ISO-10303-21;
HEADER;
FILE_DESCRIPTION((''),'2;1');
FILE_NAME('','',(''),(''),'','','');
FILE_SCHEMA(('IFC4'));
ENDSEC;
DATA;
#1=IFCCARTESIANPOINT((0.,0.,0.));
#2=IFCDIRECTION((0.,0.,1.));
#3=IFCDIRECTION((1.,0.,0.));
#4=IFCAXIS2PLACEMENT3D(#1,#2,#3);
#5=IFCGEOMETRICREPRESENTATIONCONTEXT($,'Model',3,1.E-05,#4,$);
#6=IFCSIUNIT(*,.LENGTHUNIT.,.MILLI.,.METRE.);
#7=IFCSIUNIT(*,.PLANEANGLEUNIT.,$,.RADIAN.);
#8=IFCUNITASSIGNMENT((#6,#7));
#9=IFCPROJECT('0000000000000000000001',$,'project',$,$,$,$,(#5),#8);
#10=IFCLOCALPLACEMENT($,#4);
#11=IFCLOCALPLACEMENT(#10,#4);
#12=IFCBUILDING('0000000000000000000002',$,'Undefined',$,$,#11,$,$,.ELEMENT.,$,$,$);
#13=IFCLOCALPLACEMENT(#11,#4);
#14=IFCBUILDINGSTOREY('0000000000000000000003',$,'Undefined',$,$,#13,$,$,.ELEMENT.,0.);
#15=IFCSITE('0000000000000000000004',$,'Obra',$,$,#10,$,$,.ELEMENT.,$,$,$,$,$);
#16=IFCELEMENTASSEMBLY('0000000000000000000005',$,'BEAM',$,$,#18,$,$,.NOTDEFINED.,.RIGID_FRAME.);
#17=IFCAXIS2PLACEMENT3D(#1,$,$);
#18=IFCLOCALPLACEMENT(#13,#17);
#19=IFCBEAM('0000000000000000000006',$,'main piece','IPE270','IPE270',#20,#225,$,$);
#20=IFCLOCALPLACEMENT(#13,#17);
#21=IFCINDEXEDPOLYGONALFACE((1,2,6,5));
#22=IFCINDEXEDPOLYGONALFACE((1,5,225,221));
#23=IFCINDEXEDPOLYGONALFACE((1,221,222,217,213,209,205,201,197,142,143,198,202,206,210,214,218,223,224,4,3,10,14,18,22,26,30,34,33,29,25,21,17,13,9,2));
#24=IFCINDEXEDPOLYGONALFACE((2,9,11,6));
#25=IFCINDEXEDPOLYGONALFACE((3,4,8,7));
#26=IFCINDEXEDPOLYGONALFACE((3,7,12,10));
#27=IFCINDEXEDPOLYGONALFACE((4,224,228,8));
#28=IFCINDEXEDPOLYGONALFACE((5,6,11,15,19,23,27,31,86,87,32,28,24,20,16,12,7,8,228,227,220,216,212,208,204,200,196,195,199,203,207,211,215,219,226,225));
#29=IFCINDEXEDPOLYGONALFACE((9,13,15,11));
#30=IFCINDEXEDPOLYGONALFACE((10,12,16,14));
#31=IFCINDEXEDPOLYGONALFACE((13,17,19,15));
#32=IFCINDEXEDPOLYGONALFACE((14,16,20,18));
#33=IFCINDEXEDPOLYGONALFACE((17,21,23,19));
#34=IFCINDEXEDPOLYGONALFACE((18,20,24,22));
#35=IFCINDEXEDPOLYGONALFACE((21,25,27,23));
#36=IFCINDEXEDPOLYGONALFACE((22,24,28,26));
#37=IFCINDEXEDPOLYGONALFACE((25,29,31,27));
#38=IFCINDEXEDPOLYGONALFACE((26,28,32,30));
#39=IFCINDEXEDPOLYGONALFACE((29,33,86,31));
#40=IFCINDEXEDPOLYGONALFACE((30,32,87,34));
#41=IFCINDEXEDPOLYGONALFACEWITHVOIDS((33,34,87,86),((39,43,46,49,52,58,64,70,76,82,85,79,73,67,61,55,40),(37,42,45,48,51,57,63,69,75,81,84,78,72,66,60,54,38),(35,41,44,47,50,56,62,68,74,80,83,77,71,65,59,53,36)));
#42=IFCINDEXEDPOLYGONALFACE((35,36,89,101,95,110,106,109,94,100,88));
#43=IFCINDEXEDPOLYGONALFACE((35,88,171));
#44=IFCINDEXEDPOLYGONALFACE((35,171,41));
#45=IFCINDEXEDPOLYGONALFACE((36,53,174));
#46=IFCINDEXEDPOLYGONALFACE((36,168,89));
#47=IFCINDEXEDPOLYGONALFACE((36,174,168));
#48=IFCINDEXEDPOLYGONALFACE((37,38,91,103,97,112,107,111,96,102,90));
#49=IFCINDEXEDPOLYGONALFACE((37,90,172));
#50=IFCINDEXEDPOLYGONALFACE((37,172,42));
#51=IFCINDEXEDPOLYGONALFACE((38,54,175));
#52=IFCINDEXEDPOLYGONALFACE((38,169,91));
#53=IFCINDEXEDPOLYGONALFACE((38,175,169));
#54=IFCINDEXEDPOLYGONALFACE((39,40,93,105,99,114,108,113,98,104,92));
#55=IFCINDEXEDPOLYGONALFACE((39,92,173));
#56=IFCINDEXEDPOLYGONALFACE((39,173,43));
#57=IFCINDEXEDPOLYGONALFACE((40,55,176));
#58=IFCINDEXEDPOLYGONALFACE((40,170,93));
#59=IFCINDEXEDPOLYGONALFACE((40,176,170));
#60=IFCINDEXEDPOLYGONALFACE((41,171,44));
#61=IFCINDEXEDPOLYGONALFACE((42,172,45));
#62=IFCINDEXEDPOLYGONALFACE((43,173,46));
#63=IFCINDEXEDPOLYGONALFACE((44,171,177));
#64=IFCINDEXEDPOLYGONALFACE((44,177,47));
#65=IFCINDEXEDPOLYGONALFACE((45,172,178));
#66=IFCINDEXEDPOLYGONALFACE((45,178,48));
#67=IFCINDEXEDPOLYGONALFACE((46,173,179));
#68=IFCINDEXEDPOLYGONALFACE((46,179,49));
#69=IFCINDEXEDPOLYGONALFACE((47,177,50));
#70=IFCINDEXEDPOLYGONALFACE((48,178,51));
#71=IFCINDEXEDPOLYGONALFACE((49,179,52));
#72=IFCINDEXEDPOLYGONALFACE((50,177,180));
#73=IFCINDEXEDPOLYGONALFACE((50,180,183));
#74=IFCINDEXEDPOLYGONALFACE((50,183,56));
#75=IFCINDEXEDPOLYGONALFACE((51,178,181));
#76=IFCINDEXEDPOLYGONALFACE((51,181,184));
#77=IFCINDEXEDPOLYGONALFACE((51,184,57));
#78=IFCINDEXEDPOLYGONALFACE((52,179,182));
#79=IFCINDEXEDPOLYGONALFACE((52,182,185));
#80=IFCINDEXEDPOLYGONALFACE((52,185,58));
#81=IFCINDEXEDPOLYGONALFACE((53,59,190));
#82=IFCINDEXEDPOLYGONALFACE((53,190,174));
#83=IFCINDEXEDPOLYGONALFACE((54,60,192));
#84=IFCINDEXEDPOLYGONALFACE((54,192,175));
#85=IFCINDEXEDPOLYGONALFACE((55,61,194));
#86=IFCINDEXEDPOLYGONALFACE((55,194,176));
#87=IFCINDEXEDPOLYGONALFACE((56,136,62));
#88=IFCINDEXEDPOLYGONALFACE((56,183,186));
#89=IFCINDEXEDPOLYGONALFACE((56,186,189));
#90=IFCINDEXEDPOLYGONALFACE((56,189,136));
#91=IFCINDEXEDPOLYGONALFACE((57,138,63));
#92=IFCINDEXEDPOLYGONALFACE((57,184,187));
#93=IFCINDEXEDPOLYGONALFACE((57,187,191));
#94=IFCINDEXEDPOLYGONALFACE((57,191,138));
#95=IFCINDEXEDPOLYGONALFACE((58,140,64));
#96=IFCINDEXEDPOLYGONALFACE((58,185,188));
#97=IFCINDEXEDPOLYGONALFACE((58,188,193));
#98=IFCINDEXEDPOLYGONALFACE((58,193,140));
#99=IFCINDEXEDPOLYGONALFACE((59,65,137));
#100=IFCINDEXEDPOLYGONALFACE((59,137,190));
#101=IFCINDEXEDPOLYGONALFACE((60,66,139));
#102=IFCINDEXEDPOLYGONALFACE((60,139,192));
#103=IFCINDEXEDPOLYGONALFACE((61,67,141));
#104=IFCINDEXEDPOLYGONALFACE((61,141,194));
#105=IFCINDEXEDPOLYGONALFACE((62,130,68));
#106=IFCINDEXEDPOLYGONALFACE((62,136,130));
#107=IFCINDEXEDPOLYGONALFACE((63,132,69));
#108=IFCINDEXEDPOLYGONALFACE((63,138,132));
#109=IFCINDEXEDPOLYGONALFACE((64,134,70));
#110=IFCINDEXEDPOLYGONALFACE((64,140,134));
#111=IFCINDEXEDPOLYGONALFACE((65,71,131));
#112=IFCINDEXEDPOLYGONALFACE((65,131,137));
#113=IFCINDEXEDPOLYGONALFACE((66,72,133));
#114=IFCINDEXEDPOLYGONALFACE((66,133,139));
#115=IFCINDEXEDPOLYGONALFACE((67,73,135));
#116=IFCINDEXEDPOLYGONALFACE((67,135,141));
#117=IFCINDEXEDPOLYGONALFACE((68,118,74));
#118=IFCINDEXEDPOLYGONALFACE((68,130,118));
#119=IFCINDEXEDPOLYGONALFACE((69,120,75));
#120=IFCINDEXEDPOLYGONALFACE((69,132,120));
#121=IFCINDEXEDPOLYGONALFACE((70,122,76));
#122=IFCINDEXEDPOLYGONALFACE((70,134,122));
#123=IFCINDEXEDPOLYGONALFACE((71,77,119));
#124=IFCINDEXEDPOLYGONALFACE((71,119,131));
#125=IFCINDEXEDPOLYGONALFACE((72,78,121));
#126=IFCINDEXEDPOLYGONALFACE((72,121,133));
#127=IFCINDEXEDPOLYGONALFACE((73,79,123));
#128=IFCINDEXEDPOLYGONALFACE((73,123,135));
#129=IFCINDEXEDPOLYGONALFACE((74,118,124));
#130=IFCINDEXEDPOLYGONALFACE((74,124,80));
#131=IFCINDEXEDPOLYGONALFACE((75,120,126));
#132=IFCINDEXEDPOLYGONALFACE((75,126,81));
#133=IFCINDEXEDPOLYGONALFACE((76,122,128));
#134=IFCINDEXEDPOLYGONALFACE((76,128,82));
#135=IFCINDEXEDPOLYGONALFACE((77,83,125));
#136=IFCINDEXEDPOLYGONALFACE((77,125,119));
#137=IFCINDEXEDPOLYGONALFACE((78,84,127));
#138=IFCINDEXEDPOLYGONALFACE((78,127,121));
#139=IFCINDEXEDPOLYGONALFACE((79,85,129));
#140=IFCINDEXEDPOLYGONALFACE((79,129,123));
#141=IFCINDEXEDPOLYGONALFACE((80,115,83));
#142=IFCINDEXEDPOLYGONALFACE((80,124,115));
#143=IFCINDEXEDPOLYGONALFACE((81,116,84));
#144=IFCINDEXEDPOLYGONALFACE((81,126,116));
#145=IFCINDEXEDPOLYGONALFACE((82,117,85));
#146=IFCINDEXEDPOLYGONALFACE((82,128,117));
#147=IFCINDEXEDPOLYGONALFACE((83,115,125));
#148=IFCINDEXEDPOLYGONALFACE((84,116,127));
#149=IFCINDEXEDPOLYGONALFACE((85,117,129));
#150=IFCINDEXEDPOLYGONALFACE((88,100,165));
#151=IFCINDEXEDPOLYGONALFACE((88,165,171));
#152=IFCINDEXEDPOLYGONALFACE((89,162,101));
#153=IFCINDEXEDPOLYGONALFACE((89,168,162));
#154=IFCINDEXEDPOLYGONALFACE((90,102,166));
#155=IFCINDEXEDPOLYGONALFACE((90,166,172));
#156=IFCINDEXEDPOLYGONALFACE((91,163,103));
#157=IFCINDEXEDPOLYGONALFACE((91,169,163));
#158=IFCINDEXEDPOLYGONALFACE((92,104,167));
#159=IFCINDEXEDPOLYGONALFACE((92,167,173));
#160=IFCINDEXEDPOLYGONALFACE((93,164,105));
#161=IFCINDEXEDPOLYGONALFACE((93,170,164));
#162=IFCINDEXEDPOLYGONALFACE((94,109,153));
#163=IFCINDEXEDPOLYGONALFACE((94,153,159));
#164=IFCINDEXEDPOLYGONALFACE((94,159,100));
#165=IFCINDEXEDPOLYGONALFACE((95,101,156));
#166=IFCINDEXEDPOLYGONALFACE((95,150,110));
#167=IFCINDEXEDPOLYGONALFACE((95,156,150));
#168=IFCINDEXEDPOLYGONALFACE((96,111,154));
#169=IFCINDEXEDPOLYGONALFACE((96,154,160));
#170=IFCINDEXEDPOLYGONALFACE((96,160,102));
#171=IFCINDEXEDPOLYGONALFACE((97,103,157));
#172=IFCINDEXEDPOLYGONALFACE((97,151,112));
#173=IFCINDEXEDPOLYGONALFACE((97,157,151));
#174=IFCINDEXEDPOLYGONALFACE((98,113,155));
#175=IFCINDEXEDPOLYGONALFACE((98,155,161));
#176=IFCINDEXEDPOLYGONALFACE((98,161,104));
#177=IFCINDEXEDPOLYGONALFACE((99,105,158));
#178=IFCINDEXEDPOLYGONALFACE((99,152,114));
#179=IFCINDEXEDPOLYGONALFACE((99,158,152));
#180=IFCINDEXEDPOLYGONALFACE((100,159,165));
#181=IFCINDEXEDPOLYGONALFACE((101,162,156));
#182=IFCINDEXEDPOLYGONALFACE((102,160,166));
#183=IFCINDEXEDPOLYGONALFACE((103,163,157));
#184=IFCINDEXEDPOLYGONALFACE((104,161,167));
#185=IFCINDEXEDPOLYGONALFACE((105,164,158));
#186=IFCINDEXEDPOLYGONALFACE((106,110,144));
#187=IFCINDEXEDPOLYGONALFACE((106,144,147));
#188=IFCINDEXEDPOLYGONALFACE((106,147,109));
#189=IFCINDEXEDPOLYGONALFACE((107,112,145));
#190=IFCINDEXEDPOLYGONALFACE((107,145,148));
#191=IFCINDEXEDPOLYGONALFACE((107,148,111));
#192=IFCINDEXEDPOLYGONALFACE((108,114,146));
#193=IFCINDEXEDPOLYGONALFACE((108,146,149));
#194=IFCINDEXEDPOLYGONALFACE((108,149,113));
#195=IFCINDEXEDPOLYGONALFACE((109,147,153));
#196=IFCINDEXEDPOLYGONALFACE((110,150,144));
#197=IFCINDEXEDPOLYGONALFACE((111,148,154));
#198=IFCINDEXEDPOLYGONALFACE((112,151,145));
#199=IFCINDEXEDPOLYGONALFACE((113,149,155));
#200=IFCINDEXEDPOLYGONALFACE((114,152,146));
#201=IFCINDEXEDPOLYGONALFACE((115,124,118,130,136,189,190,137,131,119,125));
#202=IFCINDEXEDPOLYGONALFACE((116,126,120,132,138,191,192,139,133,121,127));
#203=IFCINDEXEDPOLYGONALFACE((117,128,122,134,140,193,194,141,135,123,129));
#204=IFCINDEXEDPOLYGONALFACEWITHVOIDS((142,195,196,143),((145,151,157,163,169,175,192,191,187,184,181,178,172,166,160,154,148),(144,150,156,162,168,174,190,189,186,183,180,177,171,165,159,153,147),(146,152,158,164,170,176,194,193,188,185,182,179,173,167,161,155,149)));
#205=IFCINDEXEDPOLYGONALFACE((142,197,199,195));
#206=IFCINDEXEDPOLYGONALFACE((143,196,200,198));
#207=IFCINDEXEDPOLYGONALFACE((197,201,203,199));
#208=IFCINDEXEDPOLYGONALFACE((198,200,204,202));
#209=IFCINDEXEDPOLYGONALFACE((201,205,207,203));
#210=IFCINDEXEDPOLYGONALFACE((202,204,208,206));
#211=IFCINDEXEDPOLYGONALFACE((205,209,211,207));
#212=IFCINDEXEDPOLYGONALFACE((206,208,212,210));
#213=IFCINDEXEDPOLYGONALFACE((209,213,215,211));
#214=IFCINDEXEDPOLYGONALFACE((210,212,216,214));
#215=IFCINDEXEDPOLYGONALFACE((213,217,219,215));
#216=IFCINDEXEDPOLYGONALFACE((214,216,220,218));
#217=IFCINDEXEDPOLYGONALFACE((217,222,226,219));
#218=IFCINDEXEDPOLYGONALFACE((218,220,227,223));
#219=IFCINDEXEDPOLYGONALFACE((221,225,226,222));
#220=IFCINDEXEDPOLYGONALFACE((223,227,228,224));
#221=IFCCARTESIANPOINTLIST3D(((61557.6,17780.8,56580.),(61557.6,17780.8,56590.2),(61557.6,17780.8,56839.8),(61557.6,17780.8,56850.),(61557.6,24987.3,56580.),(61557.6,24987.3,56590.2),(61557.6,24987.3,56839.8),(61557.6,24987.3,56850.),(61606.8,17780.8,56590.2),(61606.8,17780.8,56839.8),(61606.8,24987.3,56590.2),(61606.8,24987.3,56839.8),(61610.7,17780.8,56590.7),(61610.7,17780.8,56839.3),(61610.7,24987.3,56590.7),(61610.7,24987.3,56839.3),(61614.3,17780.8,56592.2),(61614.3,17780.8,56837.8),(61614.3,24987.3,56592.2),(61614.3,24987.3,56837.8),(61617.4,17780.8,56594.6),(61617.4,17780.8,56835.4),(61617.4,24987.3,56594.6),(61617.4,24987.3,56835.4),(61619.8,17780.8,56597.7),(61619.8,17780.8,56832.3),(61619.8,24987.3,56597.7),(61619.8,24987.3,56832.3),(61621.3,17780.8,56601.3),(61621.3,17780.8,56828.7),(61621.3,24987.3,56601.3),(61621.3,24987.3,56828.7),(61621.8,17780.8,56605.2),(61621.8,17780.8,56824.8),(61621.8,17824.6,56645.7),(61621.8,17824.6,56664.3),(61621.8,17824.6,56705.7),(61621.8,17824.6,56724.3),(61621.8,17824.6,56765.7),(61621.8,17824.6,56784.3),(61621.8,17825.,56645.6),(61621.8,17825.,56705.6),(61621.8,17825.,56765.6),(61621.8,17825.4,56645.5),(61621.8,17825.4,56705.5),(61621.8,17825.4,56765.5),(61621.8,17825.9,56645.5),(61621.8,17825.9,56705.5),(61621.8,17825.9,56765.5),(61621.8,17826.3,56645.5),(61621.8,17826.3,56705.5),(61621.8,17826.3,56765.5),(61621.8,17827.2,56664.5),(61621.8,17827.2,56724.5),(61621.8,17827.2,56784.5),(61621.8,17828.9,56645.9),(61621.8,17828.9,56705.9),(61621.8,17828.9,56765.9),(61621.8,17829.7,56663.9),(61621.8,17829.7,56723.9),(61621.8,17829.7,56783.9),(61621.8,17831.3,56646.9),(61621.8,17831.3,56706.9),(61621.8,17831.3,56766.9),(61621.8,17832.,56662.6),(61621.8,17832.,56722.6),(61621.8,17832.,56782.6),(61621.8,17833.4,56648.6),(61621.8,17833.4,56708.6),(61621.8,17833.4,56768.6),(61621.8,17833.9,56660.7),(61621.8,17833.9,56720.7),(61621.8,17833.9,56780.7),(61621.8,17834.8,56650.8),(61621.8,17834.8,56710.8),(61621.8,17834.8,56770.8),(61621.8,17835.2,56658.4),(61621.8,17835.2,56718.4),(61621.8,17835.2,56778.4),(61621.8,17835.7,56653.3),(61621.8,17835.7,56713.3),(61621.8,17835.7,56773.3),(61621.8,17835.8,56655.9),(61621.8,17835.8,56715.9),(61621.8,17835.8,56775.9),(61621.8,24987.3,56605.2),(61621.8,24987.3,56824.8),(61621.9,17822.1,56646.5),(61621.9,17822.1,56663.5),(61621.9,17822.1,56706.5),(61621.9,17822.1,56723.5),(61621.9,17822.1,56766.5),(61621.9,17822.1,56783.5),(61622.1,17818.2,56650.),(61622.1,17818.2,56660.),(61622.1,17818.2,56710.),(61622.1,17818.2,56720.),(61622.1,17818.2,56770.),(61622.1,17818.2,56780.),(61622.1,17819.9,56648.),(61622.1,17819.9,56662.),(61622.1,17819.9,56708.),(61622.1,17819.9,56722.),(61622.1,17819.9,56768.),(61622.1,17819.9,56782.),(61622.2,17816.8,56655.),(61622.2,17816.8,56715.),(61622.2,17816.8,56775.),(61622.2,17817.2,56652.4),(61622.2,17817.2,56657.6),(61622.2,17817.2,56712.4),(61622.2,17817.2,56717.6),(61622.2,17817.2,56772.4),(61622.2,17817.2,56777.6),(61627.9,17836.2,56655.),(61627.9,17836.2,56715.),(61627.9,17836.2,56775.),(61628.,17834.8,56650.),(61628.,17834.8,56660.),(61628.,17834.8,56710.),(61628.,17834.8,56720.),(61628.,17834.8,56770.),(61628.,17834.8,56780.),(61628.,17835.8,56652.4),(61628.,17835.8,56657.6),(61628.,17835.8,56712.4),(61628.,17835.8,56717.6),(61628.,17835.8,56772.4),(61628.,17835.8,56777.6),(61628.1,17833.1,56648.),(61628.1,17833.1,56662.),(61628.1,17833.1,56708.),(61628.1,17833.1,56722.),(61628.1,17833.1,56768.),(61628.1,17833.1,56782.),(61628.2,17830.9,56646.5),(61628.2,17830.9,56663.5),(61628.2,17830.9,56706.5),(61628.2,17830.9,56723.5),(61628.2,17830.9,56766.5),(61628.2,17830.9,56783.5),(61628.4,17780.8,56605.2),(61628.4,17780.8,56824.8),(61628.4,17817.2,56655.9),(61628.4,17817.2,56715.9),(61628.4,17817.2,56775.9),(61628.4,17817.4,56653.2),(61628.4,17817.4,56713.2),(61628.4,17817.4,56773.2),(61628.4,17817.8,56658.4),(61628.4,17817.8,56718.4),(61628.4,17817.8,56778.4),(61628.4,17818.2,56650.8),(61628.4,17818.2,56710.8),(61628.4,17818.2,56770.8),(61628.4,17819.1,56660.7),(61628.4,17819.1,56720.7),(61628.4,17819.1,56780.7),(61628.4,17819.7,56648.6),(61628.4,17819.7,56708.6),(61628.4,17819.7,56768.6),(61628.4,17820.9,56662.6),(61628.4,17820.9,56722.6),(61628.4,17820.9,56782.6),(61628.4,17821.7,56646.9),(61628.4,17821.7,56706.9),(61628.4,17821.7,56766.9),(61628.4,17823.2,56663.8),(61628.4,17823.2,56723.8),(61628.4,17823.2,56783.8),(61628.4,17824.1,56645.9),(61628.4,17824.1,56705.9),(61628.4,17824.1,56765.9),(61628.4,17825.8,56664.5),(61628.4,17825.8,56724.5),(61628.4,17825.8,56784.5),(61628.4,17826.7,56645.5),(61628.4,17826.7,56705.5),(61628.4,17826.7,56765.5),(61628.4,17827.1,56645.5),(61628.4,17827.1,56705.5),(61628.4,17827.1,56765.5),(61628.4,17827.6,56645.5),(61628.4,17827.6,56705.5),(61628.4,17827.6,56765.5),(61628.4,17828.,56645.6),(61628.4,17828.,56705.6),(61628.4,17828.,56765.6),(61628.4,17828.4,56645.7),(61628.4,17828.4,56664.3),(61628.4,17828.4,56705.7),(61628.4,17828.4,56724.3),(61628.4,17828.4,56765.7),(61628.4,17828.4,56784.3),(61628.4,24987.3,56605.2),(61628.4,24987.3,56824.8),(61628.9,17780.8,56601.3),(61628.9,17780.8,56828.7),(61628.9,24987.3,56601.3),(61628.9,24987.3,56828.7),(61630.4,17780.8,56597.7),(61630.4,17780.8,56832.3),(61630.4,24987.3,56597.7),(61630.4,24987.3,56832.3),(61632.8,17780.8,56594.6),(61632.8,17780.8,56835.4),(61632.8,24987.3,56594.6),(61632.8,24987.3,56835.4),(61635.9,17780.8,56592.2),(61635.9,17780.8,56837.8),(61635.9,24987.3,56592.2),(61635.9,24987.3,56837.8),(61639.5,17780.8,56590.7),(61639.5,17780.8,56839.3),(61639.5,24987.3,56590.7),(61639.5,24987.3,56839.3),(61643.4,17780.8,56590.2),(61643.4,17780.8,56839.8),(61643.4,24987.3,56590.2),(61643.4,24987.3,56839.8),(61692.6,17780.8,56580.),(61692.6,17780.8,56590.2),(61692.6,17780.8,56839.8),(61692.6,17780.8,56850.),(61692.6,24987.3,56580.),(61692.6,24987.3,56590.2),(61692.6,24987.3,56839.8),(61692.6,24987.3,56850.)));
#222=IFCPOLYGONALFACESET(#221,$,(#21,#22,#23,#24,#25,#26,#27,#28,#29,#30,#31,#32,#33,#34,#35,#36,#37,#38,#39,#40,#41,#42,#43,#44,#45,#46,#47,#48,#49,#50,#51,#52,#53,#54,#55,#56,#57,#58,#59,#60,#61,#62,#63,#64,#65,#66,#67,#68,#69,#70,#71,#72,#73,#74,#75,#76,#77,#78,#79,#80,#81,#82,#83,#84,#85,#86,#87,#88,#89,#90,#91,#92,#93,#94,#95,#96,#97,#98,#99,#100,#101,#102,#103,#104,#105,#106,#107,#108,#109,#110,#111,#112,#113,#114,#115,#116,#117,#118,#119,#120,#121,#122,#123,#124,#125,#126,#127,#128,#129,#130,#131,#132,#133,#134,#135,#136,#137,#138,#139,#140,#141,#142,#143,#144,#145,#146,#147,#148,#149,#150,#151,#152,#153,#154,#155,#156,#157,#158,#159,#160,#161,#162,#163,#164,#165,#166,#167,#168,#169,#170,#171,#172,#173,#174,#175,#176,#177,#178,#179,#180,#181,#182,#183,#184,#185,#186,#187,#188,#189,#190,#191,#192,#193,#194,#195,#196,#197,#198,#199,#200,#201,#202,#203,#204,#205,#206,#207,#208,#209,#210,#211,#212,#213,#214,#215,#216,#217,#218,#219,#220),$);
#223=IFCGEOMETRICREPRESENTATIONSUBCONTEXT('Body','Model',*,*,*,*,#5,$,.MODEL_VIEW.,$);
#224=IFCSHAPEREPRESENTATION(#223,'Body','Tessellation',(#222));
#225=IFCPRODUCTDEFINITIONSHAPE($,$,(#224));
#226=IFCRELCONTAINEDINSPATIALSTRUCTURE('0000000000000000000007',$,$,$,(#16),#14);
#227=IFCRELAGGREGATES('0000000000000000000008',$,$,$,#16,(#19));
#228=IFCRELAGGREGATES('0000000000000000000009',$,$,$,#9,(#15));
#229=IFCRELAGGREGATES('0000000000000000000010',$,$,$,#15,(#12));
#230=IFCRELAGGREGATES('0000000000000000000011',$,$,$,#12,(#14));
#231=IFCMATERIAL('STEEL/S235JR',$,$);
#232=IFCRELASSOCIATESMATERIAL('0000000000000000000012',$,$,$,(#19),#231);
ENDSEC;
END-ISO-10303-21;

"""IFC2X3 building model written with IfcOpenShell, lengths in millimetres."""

from ifc_helpers import new_model, si_unit, frame, origin_with_axes, origin_2d_with_axis, place, context, subcontext, project, spatial, circle, i_section, extrude, clip, halfspace, source, transform, mapped, material, element, aggregate, save


model = new_model("IFC2X3")

# Units and contexts
model_context = context("Model", 3, precision=1e-05, world=origin_with_axes())
body_context = subcontext(model_context, "Body", "Model", "MODEL_VIEW")
ifc_project = project(units=[si_unit("LENGTHUNIT", "METRE", prefix="MILLI"), si_unit("PLANEANGLEUNIT", "RADIAN")], contexts=[model_context])

# Site, building, storey
site_placement = place(None, origin_with_axes())
site = spatial("IfcSite", under=ifc_project, at=site_placement, Name="Obra", CompositionType="ELEMENT")
building_placement = place(site_placement, origin_with_axes())
building = spatial("IfcBuilding", under=site, at=building_placement, Name="Undefined", CompositionType="ELEMENT")
storey_placement = place(building_placement, origin_with_axes())
storey = spatial("IfcBuildingStorey", under=building, at=storey_placement, Name="Undefined", CompositionType="ELEMENT", Elevation=0.0)

# Shared definitions
ifc_material_1 = material(Name="STEEL/S235JR")

# Element assembly, beam, opening
shared_shape_1 = source(origin_with_axes(), body_context, "Body", "SweptSolid", [
    extrude(circle(Radius=9.5, at=origin_2d_with_axis()), frame((0.0, -35.4, 0.0), z_axis=(0.0, 1.0, 0.0), x_axis=(1.0, 0.0, 0.0)), (0.0, 0.0, 1.0), 6.8),
])
assembly_1_placement = place(storey_placement, origin_with_axes())
assembly_1 = element("IfcElementAssembly", 1, at=assembly_1_placement, inside=storey, Name="BEAM", AssemblyPlace="NOTDEFINED", PredefinedType="RIGID_FRAME")
beam_1_placement = place(assembly_1_placement, frame((61625.1, 24987.3, 56715.0), z_axis=(0.0, 0.0, 1.0), x_axis=(0.0, -1.0, 0.0)))
beam_1 = element("IfcBeam", 2, at=beam_1_placement, material=ifc_material_1, Name="main piece", Description="IPE270", ObjectType="IPE270", context=body_context, shape_type="Clipping", body=[
    clip(extrude(i_section(OverallWidth=135.0, OverallDepth=270.0, WebThickness=6.6, FlangeThickness=10.2, FilletRadius=15.0, at=origin_2d_with_axis()), frame((7206.5, 0.0, 0.0), z_axis=(-1.0, 0.0, 0.0), x_axis=(0.0, -1.0, 0.0)), (0.0, 0.0, 1.0), 7206.5), halfspace(frame((7215.5, -89.1, -120.0), z_axis=(0.998367, 0.057126, 0.0), x_axis=(0.0, 0.0, 1.0)), False)),
])
opening_1_placement = place(assembly_1_placement, frame((61596.0, 17774.8, 56835.0), z_axis=(-0.057107, 0.998368, 0.0), x_axis=(0.0, 0.0, -1.0)))
element("IfcOpeningElement", 3, at=opening_1_placement, cuts=beam_1, ObjectType="Opening", context=body_context, shape_type="MappedRepresentation", body=[
    mapped(shared_shape_1, transform((60.0, 0.0, 50.0))),
    mapped(shared_shape_1, transform((120.0, 0.0, 50.0))),
    mapped(shared_shape_1, transform((180.0, 0.0, 50.0))),
])
aggregate(assembly_1, [beam_1])

save(model, "model.ifc")
